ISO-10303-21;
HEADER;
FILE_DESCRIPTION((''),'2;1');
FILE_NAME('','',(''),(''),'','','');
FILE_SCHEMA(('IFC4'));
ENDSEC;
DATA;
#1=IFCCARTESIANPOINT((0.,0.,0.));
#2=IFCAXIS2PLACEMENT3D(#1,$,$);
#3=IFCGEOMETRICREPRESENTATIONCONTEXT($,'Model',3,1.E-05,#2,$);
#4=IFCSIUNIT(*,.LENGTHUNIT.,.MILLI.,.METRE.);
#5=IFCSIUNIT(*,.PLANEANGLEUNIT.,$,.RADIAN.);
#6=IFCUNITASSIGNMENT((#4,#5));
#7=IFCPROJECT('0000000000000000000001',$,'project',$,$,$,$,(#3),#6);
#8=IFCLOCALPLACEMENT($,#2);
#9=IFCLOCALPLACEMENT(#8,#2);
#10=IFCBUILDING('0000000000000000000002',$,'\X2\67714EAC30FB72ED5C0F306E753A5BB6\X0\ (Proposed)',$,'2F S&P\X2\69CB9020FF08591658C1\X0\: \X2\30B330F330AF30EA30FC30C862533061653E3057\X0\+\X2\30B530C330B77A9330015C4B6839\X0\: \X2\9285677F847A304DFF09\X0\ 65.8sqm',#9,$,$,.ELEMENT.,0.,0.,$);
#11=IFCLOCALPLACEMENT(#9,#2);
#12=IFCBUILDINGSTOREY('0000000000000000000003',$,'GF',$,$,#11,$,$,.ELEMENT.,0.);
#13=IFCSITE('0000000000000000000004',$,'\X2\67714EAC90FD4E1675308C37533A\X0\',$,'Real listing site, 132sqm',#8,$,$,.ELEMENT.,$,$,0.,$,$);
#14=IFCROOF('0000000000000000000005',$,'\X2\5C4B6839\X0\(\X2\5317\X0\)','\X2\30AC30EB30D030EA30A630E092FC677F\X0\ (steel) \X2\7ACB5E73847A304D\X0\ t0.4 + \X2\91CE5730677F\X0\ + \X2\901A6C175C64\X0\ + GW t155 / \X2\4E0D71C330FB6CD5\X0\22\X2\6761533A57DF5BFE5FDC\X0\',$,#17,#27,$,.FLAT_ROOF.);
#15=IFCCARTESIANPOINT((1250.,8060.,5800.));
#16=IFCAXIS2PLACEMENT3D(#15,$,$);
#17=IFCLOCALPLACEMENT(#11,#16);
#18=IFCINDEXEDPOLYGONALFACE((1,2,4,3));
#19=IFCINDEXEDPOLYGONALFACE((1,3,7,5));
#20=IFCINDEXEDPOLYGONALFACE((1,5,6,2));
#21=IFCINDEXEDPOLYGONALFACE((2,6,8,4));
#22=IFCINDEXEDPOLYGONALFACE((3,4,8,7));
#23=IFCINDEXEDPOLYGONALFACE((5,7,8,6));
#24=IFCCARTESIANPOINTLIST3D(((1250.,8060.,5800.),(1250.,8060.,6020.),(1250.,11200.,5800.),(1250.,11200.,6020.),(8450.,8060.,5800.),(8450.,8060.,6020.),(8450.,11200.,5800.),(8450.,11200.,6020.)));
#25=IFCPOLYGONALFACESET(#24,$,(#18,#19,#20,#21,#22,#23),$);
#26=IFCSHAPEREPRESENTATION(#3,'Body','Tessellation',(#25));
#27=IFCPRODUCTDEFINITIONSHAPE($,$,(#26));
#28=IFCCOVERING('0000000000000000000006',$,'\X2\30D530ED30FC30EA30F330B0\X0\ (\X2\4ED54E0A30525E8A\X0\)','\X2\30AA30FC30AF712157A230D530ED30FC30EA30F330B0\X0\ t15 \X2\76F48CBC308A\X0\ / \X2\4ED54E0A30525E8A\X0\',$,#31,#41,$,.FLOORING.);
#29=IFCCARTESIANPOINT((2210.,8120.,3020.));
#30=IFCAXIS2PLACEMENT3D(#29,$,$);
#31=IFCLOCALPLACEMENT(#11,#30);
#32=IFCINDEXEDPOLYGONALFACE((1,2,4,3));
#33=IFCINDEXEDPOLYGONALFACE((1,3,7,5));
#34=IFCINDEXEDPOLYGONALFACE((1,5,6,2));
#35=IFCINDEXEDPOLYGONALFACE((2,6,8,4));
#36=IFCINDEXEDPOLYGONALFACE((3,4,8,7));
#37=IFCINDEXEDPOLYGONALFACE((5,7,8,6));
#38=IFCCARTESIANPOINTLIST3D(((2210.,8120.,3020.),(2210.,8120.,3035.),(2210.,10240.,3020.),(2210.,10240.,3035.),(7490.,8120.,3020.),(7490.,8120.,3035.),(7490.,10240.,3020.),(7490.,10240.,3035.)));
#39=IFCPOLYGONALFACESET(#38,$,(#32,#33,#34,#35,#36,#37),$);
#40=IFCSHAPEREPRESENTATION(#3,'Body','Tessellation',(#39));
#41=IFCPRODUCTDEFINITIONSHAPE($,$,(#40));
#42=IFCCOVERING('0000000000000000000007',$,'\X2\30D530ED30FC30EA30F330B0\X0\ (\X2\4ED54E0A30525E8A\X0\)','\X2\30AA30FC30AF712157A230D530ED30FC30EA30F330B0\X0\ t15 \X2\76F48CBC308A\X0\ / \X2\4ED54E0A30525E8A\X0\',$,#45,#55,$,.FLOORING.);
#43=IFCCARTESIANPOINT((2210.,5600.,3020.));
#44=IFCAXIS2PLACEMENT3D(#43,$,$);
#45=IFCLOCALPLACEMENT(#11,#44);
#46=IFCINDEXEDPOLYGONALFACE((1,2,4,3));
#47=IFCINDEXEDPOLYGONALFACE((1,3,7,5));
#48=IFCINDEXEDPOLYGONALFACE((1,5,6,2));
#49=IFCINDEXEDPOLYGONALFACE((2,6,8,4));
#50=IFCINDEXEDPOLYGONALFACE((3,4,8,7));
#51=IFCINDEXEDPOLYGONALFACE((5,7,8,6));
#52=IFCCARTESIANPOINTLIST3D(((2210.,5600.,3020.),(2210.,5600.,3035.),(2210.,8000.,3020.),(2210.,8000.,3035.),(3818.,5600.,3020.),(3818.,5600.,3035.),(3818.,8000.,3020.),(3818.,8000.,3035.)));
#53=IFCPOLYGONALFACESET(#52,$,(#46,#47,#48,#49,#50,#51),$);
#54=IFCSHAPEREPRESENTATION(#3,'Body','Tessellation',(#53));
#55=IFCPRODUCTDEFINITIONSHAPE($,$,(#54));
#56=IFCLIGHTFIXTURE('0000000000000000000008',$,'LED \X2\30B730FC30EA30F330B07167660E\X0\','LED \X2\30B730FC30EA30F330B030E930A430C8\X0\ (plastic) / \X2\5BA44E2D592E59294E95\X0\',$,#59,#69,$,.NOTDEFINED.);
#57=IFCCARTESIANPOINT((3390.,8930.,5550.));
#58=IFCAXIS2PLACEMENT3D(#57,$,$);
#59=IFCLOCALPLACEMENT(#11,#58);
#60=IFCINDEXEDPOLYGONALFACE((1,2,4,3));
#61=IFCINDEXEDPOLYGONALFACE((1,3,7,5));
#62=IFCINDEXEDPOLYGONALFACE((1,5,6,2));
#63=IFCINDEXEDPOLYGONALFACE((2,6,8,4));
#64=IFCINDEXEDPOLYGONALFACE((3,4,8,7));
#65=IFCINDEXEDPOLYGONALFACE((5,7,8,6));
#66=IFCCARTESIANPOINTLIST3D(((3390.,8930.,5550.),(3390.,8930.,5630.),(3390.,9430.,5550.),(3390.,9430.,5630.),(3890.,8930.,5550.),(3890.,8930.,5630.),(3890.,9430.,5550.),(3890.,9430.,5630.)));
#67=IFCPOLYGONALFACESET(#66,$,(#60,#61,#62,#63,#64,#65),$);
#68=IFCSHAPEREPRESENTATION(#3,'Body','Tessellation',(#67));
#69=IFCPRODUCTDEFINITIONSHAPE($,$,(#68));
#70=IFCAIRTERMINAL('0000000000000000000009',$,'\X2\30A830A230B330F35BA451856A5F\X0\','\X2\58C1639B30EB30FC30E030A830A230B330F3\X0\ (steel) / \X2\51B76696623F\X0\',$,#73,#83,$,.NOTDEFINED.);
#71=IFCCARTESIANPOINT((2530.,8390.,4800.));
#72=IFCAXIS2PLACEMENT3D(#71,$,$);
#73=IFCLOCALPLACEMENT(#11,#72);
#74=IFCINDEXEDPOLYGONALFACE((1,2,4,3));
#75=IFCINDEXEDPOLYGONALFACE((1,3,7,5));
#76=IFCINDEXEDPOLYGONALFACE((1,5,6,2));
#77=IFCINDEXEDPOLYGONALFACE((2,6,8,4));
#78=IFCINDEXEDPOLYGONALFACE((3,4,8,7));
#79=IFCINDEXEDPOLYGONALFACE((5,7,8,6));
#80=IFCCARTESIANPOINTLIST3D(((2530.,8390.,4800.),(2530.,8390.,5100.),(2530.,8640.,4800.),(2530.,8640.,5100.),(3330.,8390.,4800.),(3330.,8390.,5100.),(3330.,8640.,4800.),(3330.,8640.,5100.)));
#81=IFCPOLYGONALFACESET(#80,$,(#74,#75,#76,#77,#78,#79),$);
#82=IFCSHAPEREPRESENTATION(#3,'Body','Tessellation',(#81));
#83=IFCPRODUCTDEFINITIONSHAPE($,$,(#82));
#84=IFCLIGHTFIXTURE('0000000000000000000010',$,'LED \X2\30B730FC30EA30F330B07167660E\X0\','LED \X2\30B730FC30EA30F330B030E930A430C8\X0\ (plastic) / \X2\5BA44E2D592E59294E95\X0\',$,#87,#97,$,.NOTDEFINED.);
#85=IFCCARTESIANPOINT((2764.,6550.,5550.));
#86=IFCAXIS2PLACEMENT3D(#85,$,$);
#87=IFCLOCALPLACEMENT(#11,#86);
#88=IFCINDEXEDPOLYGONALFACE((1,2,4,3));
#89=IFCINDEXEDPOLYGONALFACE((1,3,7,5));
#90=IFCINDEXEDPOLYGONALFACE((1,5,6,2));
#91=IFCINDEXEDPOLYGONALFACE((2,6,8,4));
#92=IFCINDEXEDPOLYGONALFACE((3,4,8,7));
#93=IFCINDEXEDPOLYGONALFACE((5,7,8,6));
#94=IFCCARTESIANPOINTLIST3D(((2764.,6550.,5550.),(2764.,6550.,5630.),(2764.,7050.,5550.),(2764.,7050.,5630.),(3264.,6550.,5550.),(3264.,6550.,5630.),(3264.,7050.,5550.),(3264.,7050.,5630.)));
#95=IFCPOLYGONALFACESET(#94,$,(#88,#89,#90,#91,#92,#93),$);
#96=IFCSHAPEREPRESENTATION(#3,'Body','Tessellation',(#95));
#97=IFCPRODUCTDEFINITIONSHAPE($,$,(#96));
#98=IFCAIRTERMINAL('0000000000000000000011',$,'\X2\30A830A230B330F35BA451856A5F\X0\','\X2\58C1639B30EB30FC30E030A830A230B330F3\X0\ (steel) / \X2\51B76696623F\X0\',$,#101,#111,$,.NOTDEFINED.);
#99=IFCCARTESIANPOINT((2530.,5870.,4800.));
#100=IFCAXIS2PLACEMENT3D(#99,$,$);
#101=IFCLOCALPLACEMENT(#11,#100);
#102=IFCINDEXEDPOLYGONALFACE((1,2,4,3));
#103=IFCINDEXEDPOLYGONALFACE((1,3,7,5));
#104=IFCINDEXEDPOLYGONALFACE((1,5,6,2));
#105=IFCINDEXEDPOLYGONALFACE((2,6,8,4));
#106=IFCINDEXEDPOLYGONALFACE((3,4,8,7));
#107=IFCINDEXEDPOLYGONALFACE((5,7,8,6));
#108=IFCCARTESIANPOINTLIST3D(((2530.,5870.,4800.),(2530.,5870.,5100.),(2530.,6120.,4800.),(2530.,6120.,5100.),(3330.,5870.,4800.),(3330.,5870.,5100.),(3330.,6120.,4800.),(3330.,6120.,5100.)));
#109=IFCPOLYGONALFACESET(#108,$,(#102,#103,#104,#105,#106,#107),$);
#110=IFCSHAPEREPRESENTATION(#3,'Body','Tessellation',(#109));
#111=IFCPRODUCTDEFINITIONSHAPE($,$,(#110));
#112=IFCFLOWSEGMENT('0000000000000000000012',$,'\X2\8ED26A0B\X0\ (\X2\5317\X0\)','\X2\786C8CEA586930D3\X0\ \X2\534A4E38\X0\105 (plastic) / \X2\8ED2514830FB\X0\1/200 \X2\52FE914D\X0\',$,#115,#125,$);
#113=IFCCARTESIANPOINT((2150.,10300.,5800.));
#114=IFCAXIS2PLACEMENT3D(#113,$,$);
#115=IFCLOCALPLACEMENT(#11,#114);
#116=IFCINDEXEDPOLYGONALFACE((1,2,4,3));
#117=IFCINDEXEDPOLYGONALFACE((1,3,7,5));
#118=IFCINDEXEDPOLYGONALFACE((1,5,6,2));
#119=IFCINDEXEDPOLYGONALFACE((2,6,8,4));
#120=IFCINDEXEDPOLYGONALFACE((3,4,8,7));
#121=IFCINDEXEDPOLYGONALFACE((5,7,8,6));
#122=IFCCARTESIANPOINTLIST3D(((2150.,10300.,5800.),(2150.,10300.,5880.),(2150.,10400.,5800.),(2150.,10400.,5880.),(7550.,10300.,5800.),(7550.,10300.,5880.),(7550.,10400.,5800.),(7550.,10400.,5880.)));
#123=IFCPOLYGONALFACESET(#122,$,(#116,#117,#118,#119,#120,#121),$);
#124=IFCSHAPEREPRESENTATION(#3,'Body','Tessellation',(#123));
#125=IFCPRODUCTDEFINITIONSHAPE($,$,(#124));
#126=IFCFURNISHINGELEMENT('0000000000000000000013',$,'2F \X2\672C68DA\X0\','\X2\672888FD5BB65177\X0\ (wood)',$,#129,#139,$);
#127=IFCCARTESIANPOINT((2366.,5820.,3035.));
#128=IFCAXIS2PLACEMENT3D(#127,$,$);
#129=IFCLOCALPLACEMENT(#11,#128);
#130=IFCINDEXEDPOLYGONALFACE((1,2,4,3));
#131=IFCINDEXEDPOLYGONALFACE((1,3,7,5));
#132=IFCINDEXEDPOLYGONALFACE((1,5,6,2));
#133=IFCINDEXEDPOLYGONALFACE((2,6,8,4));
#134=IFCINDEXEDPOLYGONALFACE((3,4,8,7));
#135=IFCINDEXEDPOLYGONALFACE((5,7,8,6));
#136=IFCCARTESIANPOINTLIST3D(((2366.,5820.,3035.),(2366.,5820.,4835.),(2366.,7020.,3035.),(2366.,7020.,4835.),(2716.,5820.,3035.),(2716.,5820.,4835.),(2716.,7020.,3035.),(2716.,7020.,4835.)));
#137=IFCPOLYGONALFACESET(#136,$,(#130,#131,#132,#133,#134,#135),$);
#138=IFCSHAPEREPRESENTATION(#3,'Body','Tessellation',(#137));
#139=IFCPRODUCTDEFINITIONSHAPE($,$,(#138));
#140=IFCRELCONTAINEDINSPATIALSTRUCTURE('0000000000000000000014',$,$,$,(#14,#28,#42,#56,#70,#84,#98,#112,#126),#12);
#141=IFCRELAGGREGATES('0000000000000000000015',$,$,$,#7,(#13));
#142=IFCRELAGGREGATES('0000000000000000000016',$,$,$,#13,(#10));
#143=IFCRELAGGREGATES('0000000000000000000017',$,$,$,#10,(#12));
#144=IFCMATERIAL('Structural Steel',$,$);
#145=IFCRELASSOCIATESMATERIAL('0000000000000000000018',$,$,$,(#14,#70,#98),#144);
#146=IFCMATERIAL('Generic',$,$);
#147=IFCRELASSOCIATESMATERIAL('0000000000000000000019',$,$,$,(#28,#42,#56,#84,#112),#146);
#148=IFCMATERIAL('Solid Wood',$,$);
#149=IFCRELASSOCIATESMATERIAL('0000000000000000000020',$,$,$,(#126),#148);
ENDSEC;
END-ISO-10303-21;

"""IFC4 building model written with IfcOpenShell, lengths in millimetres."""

from ifc_helpers import new_model, si_unit, frame, frame_2d, origin, place, context, project, spatial, rectangle, extrude, material, element, save


model = new_model("IFC4")

# Units and contexts
model_context = context("Model", 3, precision=1e-05, world=origin())
ifc_project = project(units=[si_unit("LENGTHUNIT", "METRE", prefix="MILLI"), si_unit("PLANEANGLEUNIT", "RADIAN")], contexts=[model_context])

# Site, building, storey
site_placement = place(None, origin())
site = spatial("IfcSite", under=ifc_project, at=site_placement, Name="東京都世田谷区", ObjectType="Real listing site, 132sqm", CompositionType="ELEMENT", RefElevation=0.0)
building_placement = place(site_placement, origin())
building = spatial("IfcBuilding", under=site, at=building_placement, Name="東京・狭小の町家 (Proposed)", ObjectType="2F S&P構造（外壁: コンクリート打ち放し+サッシ窓、屋根: 銅板葺き） 65.8sqm", CompositionType="ELEMENT", ElevationOfRefHeight=0.0, ElevationOfTerrain=0.0)
storey_placement = place(building_placement, origin())
storey = spatial("IfcBuildingStorey", under=building, at=storey_placement, Name="GF", CompositionType="ELEMENT", Elevation=0.0)

# Shared definitions
ifc_material_1 = material(Name="Solid Wood")

# Roof
ifc_material_2 = material(Name="Structural Steel")
for number, where, name in (
    (1, (1250.0, 8060.0, 5800.0), "屋根(北)"),
):
    element("IfcRoof", number, at=place(storey_placement, frame(where)), inside=storey, material=ifc_material_2, Name=name, Description="ガルバリウム鋼板 (steel) 立平葺き t0.4 + 野地板 + 通気層 + GW t155 / 不燃・法22条区域対応", PredefinedType="FLAT_ROOF", context=model_context, shape_type="SweptSolid", body=[
        extrude(rectangle(XDim=7200.0, YDim=3140.0, at=frame_2d((3600.0, 1570.0))), frame((1250.0, 8060.0, 5800.0)), (0.0, 0.0, 1.0), 220.0),
    ])

# Coverings
ifc_material_3 = material(Name="Generic")
covering_1_placement = place(storey_placement, frame((2210.0, 8120.0, 3020.0)))
element("IfcCovering", 2, at=covering_1_placement, inside=storey, material=ifc_material_3, Name="フローリング (仕上げ床)", Description="オーク無垢フローリング t15 直貼り / 仕上げ床", PredefinedType="FLOORING", context=model_context, shape_type="SweptSolid", body=[
    extrude(rectangle(XDim=5280.0, YDim=2120.0, at=frame_2d((2640.0, 1060.0))), frame((2210.0, 8120.0, 3020.0)), (0.0, 0.0, 1.0), 15.0),
])
covering_2_placement = place(storey_placement, frame((2210.0, 5600.0, 3020.0)))
element("IfcCovering", 3, at=covering_2_placement, inside=storey, material=ifc_material_3, Name="フローリング (仕上げ床)", Description="オーク無垢フローリング t15 直貼り / 仕上げ床", PredefinedType="FLOORING", context=model_context, shape_type="SweptSolid", body=[
    extrude(rectangle(XDim=1608.0, YDim=2400.0, at=frame_2d((804.0, 1200.0))), frame((2210.0, 5600.0, 3020.0)), (0.0, 0.0, 1.0), 15.0),
])

# Light fixture
light_fixture_1_placement = place(storey_placement, frame((3390.0, 8930.0, 5550.0)))
element("IfcLightFixture", 4, at=light_fixture_1_placement, inside=storey, material=ifc_material_3, Name="LED シーリング照明", Description="LED シーリングライト (plastic) / 室中央天井", PredefinedType="NOTDEFINED", context=model_context, shape_type="SweptSolid", body=[
    extrude(rectangle(XDim=500.0, YDim=500.0, at=frame_2d((250.0, 250.0))), frame((3390.0, 8930.0, 5550.0)), (0.0, 0.0, 1.0), 80.0),
])

# Air terminal
air_terminal_1_placement = place(storey_placement, frame((2530.0, 8390.0, 4800.0)))
element("IfcAirTerminal", 5, at=air_terminal_1_placement, inside=storey, material=ifc_material_2, Name="エアコン室内機", Description="壁掛ルームエアコン (steel) / 冷暖房", PredefinedType="NOTDEFINED", context=model_context, shape_type="SweptSolid", body=[
    extrude(rectangle(XDim=800.0, YDim=250.0, at=frame_2d((400.0, 125.0))), frame((2530.0, 8390.0, 4800.0)), (0.0, 0.0, 1.0), 300.0),
])

# Light fixture
light_fixture_2_placement = place(storey_placement, frame((2764.0, 6550.0, 5550.0)))
element("IfcLightFixture", 6, at=light_fixture_2_placement, inside=storey, material=ifc_material_3, Name="LED シーリング照明", Description="LED シーリングライト (plastic) / 室中央天井", PredefinedType="NOTDEFINED", context=model_context, shape_type="SweptSolid", body=[
    extrude(rectangle(XDim=500.0, YDim=500.0, at=frame_2d((250.0, 250.0))), frame((2764.0, 6550.0, 5550.0)), (0.0, 0.0, 1.0), 80.0),
])

# Air terminal
air_terminal_2_placement = place(storey_placement, frame((2530.0, 5870.0, 4800.0)))
element("IfcAirTerminal", 7, at=air_terminal_2_placement, inside=storey, material=ifc_material_2, Name="エアコン室内機", Description="壁掛ルームエアコン (steel) / 冷暖房", PredefinedType="NOTDEFINED", context=model_context, shape_type="SweptSolid", body=[
    extrude(rectangle(XDim=800.0, YDim=250.0, at=frame_2d((400.0, 125.0))), frame((2530.0, 5870.0, 4800.0)), (0.0, 0.0, 1.0), 300.0),
])

# Flow segment
flow_segment_placement = place(storey_placement, frame((2150.0, 10300.0, 5800.0)))
element("IfcFlowSegment", 8, at=flow_segment_placement, inside=storey, material=ifc_material_3, Name="軒樋 (北)", Description="硬質塩ビ 半丸105 (plastic) / 軒先・1/200 勾配", context=model_context, shape_type="SweptSolid", body=[
    extrude(rectangle(XDim=5400.0, YDim=100.0, at=frame_2d((2700.0, 50.0))), frame((2150.0, 10300.0, 5800.0)), (0.0, 0.0, 1.0), 80.0),
])

# Furnishing element
furnishing_placement = place(storey_placement, frame((2366.0, 5820.0, 3035.0)))
element("IfcFurnishingElement", 9, at=furnishing_placement, inside=storey, material=ifc_material_1, Name="2F 本棚", Description="木製家具 (wood)", context=model_context, shape_type="SweptSolid", body=[
    extrude(rectangle(XDim=350.0, YDim=1200.0, at=frame_2d((175.0, 600.0))), frame((2366.0, 5820.0, 3035.0)), (0.0, 0.0, 1.0), 1800.0),
])

save(model, "model.ifc")
